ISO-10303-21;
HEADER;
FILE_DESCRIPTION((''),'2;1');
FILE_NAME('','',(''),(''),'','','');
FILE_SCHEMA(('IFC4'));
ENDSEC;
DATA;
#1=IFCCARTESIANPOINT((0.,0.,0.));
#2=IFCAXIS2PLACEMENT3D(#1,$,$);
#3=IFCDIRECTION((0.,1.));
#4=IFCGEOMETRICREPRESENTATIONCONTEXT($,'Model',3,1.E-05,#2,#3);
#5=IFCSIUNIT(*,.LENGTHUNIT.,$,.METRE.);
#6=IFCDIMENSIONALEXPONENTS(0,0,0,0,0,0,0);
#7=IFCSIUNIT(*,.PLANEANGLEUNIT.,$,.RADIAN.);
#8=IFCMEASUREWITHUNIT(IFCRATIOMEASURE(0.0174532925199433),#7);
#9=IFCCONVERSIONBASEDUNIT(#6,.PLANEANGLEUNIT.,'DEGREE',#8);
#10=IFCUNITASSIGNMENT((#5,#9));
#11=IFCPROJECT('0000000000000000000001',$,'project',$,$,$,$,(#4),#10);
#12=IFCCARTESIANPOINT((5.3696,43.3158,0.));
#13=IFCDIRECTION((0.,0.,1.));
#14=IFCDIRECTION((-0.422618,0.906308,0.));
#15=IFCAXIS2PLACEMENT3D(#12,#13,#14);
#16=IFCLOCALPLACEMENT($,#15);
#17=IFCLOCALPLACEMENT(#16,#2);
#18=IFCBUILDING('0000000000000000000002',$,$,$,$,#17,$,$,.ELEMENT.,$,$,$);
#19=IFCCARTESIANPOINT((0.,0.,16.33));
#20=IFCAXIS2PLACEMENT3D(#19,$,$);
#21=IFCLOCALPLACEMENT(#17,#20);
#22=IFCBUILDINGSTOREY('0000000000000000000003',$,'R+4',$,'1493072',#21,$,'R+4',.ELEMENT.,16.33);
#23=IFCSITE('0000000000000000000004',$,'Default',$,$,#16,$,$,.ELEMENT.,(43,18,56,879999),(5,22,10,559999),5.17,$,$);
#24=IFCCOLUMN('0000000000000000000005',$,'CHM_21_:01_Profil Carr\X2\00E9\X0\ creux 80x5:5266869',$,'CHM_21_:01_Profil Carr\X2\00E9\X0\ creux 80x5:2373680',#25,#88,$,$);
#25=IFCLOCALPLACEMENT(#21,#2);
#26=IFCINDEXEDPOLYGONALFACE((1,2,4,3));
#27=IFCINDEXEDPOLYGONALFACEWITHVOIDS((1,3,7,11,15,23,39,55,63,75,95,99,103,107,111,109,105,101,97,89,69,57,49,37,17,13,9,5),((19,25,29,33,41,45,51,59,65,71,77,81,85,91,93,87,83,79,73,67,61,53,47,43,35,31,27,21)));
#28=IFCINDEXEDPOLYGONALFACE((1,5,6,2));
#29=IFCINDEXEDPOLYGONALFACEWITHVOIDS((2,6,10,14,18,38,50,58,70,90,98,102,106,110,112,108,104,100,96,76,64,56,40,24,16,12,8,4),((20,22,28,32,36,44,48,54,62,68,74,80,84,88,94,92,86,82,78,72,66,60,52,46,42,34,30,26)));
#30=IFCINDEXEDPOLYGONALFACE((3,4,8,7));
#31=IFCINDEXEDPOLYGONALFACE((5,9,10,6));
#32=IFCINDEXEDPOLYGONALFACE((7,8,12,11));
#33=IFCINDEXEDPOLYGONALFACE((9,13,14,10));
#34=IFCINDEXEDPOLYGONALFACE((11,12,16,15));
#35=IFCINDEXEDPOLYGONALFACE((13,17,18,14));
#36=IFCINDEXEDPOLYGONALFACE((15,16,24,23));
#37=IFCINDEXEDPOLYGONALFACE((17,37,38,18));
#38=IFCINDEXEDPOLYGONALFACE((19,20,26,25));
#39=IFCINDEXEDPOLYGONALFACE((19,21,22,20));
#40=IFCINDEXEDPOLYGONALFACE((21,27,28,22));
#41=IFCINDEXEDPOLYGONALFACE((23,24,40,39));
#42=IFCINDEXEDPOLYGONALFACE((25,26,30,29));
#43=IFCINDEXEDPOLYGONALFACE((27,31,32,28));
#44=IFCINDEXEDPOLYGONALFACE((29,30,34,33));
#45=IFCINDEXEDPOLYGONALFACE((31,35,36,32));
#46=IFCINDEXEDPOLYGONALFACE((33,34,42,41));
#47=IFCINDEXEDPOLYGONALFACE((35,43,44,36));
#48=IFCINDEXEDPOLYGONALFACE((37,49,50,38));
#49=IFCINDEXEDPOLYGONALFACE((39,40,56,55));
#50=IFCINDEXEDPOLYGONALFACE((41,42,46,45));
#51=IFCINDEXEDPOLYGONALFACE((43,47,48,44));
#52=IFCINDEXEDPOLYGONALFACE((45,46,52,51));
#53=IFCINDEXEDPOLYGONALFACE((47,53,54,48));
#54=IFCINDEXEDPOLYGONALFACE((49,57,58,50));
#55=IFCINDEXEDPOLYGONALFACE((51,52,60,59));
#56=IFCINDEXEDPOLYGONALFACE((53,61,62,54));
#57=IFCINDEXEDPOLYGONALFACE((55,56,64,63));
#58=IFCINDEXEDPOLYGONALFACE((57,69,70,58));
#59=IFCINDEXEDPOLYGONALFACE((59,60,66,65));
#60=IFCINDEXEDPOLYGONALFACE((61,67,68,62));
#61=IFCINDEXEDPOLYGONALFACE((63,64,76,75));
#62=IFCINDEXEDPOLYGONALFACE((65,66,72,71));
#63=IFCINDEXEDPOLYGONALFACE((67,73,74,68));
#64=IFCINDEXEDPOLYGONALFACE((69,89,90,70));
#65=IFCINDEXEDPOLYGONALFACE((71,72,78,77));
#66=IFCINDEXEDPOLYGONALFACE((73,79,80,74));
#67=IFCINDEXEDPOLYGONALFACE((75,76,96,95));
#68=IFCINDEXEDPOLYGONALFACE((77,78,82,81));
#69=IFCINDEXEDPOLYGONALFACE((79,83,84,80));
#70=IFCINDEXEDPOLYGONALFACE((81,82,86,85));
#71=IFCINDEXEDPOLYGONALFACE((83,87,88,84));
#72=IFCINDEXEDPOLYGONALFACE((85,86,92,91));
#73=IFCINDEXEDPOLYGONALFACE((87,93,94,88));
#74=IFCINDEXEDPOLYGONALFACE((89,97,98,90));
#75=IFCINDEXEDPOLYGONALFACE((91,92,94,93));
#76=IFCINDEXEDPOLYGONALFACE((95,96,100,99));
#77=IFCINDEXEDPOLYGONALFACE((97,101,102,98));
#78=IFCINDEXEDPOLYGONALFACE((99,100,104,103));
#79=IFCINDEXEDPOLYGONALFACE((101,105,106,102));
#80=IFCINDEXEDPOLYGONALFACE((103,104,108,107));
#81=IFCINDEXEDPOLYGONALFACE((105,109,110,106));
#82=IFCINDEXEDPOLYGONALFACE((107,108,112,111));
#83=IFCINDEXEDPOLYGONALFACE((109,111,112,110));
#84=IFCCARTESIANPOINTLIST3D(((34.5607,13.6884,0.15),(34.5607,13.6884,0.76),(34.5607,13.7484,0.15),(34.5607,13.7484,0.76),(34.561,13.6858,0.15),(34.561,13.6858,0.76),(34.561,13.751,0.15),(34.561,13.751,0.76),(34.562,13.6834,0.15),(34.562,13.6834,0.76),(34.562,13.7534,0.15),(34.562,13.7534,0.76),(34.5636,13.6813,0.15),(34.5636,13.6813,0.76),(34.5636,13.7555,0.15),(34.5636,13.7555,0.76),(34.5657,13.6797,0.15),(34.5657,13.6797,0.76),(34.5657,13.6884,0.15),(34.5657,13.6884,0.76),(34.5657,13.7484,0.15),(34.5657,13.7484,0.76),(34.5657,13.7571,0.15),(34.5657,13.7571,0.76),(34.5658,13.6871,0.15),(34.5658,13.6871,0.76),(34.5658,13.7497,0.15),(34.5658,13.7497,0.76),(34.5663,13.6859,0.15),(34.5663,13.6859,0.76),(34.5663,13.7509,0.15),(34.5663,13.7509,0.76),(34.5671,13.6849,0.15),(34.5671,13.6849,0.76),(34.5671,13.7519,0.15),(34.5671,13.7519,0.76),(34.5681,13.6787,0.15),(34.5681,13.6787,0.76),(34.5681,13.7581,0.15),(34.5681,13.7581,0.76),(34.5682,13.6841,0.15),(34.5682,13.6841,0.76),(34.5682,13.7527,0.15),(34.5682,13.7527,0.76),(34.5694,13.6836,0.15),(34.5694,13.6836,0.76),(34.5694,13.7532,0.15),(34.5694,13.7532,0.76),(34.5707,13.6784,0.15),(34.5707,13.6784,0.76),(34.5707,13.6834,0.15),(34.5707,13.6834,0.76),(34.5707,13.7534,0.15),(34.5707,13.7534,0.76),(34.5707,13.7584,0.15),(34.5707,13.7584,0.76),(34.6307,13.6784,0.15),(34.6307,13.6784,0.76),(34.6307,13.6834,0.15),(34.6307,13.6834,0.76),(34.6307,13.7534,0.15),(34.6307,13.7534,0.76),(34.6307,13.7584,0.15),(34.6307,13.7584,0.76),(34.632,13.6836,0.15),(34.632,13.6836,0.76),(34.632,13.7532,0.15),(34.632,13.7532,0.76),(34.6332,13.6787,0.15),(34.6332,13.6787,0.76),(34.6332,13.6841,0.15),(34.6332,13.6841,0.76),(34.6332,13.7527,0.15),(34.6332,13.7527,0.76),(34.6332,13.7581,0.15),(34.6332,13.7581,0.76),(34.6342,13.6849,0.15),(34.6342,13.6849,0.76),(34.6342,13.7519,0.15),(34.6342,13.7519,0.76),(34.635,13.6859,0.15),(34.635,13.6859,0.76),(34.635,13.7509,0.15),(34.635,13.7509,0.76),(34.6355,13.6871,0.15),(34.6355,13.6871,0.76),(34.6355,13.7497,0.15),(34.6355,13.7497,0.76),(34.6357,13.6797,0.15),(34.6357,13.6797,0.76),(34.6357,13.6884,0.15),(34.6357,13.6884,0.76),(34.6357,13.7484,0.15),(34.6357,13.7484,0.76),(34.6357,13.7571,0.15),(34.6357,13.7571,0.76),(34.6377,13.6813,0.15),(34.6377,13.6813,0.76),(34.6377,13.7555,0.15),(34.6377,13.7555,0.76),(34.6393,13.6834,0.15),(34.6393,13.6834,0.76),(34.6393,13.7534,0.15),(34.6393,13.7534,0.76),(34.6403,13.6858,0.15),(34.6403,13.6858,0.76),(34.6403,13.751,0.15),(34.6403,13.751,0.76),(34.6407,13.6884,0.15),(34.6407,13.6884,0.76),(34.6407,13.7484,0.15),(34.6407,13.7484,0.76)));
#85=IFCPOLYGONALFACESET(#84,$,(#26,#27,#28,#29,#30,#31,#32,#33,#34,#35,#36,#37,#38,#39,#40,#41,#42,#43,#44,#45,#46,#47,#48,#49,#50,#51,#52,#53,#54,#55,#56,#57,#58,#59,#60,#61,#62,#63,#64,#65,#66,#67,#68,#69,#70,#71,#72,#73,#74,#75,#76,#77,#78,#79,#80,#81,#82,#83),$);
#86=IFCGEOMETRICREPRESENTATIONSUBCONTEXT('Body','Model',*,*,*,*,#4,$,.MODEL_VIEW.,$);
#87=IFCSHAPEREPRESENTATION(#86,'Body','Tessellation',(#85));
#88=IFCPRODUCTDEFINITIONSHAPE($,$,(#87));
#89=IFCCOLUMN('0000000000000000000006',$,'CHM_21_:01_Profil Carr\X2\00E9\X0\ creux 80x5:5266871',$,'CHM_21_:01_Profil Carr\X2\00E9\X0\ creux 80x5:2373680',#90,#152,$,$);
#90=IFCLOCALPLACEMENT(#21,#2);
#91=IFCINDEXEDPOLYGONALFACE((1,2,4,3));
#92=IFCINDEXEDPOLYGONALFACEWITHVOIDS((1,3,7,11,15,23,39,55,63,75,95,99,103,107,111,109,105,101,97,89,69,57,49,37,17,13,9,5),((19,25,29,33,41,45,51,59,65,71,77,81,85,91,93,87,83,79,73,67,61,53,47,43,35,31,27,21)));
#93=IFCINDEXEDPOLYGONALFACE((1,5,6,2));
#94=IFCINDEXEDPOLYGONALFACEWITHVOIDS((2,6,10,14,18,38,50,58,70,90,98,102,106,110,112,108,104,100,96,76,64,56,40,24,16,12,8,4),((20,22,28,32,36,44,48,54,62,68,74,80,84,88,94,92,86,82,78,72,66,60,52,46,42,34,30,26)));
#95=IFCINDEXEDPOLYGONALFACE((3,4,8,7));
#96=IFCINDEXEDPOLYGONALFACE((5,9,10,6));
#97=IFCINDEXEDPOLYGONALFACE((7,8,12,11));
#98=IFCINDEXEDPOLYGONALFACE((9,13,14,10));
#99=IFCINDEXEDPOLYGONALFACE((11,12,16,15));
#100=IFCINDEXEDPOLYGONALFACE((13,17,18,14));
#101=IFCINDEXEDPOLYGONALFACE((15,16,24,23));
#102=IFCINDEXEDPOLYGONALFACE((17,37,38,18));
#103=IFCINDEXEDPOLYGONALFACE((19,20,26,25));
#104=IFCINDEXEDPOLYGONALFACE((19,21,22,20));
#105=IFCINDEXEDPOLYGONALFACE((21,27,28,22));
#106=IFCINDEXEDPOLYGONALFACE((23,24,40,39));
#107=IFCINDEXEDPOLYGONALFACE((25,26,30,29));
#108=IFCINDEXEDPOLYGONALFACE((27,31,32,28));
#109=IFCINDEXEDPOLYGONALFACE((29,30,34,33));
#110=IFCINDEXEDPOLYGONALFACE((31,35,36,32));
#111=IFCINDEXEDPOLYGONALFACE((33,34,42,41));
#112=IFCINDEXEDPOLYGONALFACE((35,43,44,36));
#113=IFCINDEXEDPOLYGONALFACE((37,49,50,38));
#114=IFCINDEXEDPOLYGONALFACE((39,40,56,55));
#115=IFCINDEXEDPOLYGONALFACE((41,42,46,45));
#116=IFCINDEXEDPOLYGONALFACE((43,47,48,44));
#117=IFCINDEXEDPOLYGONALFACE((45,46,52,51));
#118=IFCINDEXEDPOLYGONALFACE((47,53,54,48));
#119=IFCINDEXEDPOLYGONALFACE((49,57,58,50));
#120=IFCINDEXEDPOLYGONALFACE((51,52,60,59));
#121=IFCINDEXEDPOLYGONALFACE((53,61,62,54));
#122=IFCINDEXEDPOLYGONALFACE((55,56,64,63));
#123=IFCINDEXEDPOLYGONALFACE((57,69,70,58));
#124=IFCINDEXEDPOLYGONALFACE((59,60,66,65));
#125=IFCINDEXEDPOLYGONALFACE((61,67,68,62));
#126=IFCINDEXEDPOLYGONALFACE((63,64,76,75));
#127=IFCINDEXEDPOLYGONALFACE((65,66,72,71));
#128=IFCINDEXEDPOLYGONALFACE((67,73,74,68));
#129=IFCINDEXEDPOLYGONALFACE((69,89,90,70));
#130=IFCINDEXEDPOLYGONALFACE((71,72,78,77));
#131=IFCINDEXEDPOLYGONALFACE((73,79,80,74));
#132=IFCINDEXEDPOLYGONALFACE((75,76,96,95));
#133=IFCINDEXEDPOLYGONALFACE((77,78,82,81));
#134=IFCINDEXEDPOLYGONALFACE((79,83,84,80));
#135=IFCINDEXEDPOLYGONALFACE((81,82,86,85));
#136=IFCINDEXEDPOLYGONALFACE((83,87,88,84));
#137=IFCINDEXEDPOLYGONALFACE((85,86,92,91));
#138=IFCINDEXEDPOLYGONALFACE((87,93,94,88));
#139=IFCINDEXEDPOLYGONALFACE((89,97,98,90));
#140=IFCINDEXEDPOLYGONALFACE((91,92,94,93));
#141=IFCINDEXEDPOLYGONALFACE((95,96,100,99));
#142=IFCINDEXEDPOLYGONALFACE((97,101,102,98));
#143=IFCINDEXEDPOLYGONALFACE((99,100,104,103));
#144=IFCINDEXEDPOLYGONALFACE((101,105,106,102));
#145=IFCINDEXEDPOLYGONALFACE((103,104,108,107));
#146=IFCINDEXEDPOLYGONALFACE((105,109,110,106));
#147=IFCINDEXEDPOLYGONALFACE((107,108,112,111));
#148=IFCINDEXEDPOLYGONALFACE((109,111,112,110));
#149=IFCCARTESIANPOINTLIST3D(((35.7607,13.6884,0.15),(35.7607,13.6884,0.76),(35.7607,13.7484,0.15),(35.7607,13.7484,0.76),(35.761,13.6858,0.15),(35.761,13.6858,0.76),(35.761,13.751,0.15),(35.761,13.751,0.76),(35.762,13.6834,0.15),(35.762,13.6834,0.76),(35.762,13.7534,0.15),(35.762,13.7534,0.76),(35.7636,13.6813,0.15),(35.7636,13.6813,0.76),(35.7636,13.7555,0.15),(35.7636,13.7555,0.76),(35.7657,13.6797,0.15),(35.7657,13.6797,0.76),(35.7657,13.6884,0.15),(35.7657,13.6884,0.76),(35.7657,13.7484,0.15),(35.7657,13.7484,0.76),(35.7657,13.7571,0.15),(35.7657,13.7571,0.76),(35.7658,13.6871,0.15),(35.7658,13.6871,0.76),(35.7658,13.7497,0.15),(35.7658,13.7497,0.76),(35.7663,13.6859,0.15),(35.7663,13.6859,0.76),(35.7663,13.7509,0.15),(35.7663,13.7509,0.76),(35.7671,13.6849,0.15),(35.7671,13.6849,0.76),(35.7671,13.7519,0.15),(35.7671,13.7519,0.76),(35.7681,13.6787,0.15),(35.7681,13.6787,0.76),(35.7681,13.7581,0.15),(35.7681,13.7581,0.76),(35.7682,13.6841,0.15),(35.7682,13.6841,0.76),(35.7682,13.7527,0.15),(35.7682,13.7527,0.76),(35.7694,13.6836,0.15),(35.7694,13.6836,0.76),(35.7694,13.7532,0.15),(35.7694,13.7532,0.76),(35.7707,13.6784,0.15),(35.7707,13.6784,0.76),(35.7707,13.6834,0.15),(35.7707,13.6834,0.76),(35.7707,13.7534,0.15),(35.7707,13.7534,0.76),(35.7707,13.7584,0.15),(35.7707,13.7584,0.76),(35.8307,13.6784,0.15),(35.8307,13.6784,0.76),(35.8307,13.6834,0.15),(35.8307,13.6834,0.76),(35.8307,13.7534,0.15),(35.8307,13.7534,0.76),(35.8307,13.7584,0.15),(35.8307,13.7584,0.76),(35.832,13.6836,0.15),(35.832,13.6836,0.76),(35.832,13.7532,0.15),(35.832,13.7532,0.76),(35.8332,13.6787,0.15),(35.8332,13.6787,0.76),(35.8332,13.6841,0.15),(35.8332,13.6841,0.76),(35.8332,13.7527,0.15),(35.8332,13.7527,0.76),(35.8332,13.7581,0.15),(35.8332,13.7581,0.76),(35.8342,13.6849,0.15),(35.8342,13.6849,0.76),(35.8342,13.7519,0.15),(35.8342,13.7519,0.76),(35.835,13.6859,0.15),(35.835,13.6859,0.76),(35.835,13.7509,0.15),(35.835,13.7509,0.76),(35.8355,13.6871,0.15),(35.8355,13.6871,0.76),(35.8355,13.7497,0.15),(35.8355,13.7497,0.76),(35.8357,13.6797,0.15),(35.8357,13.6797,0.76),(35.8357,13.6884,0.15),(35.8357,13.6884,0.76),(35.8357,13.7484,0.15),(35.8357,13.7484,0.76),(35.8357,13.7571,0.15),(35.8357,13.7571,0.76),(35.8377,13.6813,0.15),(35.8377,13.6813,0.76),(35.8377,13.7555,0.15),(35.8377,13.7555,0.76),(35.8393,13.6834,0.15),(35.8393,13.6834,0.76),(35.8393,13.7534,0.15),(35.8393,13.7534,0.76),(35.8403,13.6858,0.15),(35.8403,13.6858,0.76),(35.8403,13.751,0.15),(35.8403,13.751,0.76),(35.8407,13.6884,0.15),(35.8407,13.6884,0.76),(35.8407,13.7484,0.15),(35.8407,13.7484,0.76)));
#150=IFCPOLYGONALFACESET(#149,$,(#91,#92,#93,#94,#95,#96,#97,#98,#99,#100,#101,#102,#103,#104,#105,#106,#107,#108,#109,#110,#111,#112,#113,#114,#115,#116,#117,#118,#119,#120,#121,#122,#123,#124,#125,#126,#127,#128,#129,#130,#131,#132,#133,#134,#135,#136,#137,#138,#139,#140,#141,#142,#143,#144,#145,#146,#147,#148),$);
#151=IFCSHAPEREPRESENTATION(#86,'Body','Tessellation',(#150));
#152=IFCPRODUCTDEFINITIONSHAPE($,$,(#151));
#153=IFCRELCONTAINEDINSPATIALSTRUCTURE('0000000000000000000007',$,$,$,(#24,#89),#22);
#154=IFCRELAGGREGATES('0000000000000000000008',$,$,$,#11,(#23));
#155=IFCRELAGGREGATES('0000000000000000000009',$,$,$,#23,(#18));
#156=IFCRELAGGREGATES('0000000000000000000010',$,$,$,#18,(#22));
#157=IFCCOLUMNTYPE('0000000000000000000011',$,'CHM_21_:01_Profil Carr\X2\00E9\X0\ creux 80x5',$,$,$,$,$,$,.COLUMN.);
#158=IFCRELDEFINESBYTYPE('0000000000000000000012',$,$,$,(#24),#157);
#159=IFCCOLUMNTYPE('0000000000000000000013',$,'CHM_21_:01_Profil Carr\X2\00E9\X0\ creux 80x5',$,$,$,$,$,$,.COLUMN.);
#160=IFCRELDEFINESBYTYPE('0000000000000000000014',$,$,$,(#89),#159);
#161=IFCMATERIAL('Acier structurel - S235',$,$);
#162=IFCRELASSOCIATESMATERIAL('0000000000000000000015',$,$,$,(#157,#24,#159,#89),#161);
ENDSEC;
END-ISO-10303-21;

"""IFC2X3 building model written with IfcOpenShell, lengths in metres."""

from ifc_helpers import new_model, entity, si_unit, converted_unit, direction, frame, frame_2d, origin, place, context, subcontext, project, spatial, polyline, circle_curve, parameter, trimmed, segment, composite_curve, outline, extrude, source, transform, mapped, material, type_object, type_shapes, element, save


model = new_model("IFC2X3")

# Units and contexts
model_context = context("Model", 3, precision=1e-05, world=origin(), true_north=direction((0.0, 1.0)))
body_context = subcontext(model_context, "Body", "Model", "MODEL_VIEW")
ifc_project = project(units=[si_unit("LENGTHUNIT", "METRE"), converted_unit("PLANEANGLEUNIT", "DEGREE", entity("IfcRatioMeasure", 0.0174532925199433), si_unit("PLANEANGLEUNIT", "RADIAN"), dimensions=[0, 0, 0, 0, 0, 0, 0])], contexts=[model_context])

# Site, building, storey
site_placement = place(None, frame((5.3696, 43.3158, 0.0), z_axis=(0.0, 0.0, 1.0), x_axis=(-0.422618, 0.906308, 0.0)))
site = spatial("IfcSite", under=ifc_project, at=site_placement, Name="Default", CompositionType="ELEMENT", RefLatitude=(43, 18, 56, 879999), RefLongitude=(5, 22, 10, 559999), RefElevation=5.17)
building_placement = place(site_placement, origin())
building = spatial("IfcBuilding", under=site, at=building_placement, CompositionType="ELEMENT")
storey_placement = place(building_placement, frame((0.0, 0.0, 16.33)))
storey = spatial("IfcBuildingStorey", under=building, at=storey_placement, Name="R+4", ObjectType="1493072", LongName="R+4", CompositionType="ELEMENT", Elevation=16.33)

# Columns
ifc_material_1 = material(Name="Acier structurel - S235")
column_type_1 = type_object("IfcColumnType", Name="CHM_21_:01_Profil Carré creux 80x5", PredefinedType="COLUMN", material=ifc_material_1)
shared_shape_1 = source(origin(), body_context, "Body", "SweptSolid", [
    extrude(outline(composite_curve([segment(polyline([(-0.03, -0.04), (0.03, -0.04)]), True, "CONTINUOUS"), segment(trimmed(circle_curve(frame_2d((0.03, -0.03), x_axis=(-1.0, 0.0)), 0.01), [parameter(90.0)], [parameter(180.0)], True, "PARAMETER"), True, "CONTINUOUS"), segment(polyline([(0.04, -0.03), (0.04, 0.03)]), True, "CONTINUOUS"), segment(trimmed(circle_curve(frame_2d((0.03, 0.03), x_axis=(-1.0, 0.0)), 0.01), [parameter(180.0)], [parameter(270.0)], True, "PARAMETER"), True, "CONTINUOUS"), segment(polyline([(0.03, 0.04), (-0.03, 0.04)]), True, "CONTINUOUS"), segment(trimmed(circle_curve(frame_2d((-0.03, 0.03), x_axis=(-1.0, 0.0)), 0.01), [parameter(270.0)], [parameter(360.0)], True, "PARAMETER"), True, "CONTINUOUS"), segment(polyline([(-0.04, 0.03), (-0.04, -0.03)]), True, "CONTINUOUS"), segment(trimmed(circle_curve(frame_2d((-0.03, -0.03), x_axis=(-1.0, 0.0)), 0.01), [parameter(360.0)], [parameter(90.0)], True, "PARAMETER"), True, "CONTINUOUS")], self_intersect=False), holes=[composite_curve([segment(trimmed(circle_curve(frame_2d((-0.03, -0.03), x_axis=(-1.0, 0.0)), 0.005), [parameter(360.0)], [parameter(90.0)], True, "PARAMETER"), False, "CONTINUOUS"), segment(polyline([(-0.035, -0.03), (-0.035, 0.03)]), True, "CONTINUOUS"), segment(trimmed(circle_curve(frame_2d((-0.03, 0.03), x_axis=(-1.0, 0.0)), 0.005), [parameter(270.0)], [parameter(360.0)], True, "PARAMETER"), False, "CONTINUOUS"), segment(polyline([(-0.03, 0.035), (0.03, 0.035)]), True, "CONTINUOUS"), segment(trimmed(circle_curve(frame_2d((0.03, 0.03), x_axis=(-1.0, 0.0)), 0.005), [parameter(180.0)], [parameter(270.0)], True, "PARAMETER"), False, "CONTINUOUS"), segment(polyline([(0.035, 0.03), (0.035, -0.03)]), True, "CONTINUOUS"), segment(trimmed(circle_curve(frame_2d((0.03, -0.03), x_axis=(-1.0, 0.0)), 0.005), [parameter(90.0)], [parameter(180.0)], True, "PARAMETER"), False, "CONTINUOUS"), segment(polyline([(0.03, -0.035), (-0.03, -0.035)]), True, "CONTINUOUS")], self_intersect=False)]), frame((34.6007, 13.7184, 16.48), z_axis=(0.0, 0.0, 1.0), x_axis=(0.0, 1.0, 0.0)), (0.0, 0.0, 1.0), 0.61),
])
type_shapes(column_type_1, [shared_shape_1])
column_1_placement = place(storey_placement, frame((0.0, 0.0, -16.33)))
element("IfcColumn", 1, at=column_1_placement, inside=storey, type_object=column_type_1, material=ifc_material_1, Name="CHM_21_:01_Profil Carré creux 80x5:5266869", ObjectType="CHM_21_:01_Profil Carré creux 80x5:2373680", context=body_context, shape_type="MappedRepresentation", body=[
    mapped(shared_shape_1, transform((0.0, 0.0, 0.0), scale=1.0)),
])
column_type_2 = type_object("IfcColumnType", Name="CHM_21_:01_Profil Carré creux 80x5", PredefinedType="COLUMN", material=ifc_material_1)
shared_shape_2 = source(origin(), body_context, "Body", "SweptSolid", [
    extrude(outline(composite_curve([segment(polyline([(-0.03, -0.04), (0.03, -0.04)]), True, "CONTINUOUS"), segment(trimmed(circle_curve(frame_2d((0.03, -0.03), x_axis=(-1.0, 0.0)), 0.01), [parameter(90.0)], [parameter(180.0)], True, "PARAMETER"), True, "CONTINUOUS"), segment(polyline([(0.04, -0.03), (0.04, 0.03)]), True, "CONTINUOUS"), segment(trimmed(circle_curve(frame_2d((0.03, 0.03), x_axis=(-1.0, 0.0)), 0.01), [parameter(180.0)], [parameter(270.0)], True, "PARAMETER"), True, "CONTINUOUS"), segment(polyline([(0.03, 0.04), (-0.03, 0.04)]), True, "CONTINUOUS"), segment(trimmed(circle_curve(frame_2d((-0.03, 0.03), x_axis=(-1.0, 0.0)), 0.01), [parameter(270.0)], [parameter(360.0)], True, "PARAMETER"), True, "CONTINUOUS"), segment(polyline([(-0.04, 0.03), (-0.04, -0.03)]), True, "CONTINUOUS"), segment(trimmed(circle_curve(frame_2d((-0.03, -0.03), x_axis=(-1.0, 0.0)), 0.01), [parameter(360.0)], [parameter(90.0)], True, "PARAMETER"), True, "CONTINUOUS")], self_intersect=False), holes=[composite_curve([segment(trimmed(circle_curve(frame_2d((-0.03, -0.03), x_axis=(-1.0, 0.0)), 0.005), [parameter(360.0)], [parameter(90.0)], True, "PARAMETER"), False, "CONTINUOUS"), segment(polyline([(-0.035, -0.03), (-0.035, 0.03)]), True, "CONTINUOUS"), segment(trimmed(circle_curve(frame_2d((-0.03, 0.03), x_axis=(-1.0, 0.0)), 0.005), [parameter(270.0)], [parameter(360.0)], True, "PARAMETER"), False, "CONTINUOUS"), segment(polyline([(-0.03, 0.035), (0.03, 0.035)]), True, "CONTINUOUS"), segment(trimmed(circle_curve(frame_2d((0.03, 0.03), x_axis=(-1.0, 0.0)), 0.005), [parameter(180.0)], [parameter(270.0)], True, "PARAMETER"), False, "CONTINUOUS"), segment(polyline([(0.035, 0.03), (0.035, -0.03)]), True, "CONTINUOUS"), segment(trimmed(circle_curve(frame_2d((0.03, -0.03), x_axis=(-1.0, 0.0)), 0.005), [parameter(90.0)], [parameter(180.0)], True, "PARAMETER"), False, "CONTINUOUS"), segment(polyline([(0.03, -0.035), (-0.03, -0.035)]), True, "CONTINUOUS")], self_intersect=False)]), frame((35.8007, 13.7184, 16.48), z_axis=(0.0, 0.0, 1.0), x_axis=(0.0, 1.0, 0.0)), (0.0, 0.0, 1.0), 0.61),
])
type_shapes(column_type_2, [shared_shape_2])
column_2_placement = place(storey_placement, frame((0.0, 0.0, -16.33)))
element("IfcColumn", 2, at=column_2_placement, inside=storey, type_object=column_type_2, material=ifc_material_1, Name="CHM_21_:01_Profil Carré creux 80x5:5266871", ObjectType="CHM_21_:01_Profil Carré creux 80x5:2373680", context=body_context, shape_type="MappedRepresentation", body=[
    mapped(shared_shape_2, transform((0.0, 0.0, 0.0), scale=1.0)),
])

save(model, "model.ifc")
